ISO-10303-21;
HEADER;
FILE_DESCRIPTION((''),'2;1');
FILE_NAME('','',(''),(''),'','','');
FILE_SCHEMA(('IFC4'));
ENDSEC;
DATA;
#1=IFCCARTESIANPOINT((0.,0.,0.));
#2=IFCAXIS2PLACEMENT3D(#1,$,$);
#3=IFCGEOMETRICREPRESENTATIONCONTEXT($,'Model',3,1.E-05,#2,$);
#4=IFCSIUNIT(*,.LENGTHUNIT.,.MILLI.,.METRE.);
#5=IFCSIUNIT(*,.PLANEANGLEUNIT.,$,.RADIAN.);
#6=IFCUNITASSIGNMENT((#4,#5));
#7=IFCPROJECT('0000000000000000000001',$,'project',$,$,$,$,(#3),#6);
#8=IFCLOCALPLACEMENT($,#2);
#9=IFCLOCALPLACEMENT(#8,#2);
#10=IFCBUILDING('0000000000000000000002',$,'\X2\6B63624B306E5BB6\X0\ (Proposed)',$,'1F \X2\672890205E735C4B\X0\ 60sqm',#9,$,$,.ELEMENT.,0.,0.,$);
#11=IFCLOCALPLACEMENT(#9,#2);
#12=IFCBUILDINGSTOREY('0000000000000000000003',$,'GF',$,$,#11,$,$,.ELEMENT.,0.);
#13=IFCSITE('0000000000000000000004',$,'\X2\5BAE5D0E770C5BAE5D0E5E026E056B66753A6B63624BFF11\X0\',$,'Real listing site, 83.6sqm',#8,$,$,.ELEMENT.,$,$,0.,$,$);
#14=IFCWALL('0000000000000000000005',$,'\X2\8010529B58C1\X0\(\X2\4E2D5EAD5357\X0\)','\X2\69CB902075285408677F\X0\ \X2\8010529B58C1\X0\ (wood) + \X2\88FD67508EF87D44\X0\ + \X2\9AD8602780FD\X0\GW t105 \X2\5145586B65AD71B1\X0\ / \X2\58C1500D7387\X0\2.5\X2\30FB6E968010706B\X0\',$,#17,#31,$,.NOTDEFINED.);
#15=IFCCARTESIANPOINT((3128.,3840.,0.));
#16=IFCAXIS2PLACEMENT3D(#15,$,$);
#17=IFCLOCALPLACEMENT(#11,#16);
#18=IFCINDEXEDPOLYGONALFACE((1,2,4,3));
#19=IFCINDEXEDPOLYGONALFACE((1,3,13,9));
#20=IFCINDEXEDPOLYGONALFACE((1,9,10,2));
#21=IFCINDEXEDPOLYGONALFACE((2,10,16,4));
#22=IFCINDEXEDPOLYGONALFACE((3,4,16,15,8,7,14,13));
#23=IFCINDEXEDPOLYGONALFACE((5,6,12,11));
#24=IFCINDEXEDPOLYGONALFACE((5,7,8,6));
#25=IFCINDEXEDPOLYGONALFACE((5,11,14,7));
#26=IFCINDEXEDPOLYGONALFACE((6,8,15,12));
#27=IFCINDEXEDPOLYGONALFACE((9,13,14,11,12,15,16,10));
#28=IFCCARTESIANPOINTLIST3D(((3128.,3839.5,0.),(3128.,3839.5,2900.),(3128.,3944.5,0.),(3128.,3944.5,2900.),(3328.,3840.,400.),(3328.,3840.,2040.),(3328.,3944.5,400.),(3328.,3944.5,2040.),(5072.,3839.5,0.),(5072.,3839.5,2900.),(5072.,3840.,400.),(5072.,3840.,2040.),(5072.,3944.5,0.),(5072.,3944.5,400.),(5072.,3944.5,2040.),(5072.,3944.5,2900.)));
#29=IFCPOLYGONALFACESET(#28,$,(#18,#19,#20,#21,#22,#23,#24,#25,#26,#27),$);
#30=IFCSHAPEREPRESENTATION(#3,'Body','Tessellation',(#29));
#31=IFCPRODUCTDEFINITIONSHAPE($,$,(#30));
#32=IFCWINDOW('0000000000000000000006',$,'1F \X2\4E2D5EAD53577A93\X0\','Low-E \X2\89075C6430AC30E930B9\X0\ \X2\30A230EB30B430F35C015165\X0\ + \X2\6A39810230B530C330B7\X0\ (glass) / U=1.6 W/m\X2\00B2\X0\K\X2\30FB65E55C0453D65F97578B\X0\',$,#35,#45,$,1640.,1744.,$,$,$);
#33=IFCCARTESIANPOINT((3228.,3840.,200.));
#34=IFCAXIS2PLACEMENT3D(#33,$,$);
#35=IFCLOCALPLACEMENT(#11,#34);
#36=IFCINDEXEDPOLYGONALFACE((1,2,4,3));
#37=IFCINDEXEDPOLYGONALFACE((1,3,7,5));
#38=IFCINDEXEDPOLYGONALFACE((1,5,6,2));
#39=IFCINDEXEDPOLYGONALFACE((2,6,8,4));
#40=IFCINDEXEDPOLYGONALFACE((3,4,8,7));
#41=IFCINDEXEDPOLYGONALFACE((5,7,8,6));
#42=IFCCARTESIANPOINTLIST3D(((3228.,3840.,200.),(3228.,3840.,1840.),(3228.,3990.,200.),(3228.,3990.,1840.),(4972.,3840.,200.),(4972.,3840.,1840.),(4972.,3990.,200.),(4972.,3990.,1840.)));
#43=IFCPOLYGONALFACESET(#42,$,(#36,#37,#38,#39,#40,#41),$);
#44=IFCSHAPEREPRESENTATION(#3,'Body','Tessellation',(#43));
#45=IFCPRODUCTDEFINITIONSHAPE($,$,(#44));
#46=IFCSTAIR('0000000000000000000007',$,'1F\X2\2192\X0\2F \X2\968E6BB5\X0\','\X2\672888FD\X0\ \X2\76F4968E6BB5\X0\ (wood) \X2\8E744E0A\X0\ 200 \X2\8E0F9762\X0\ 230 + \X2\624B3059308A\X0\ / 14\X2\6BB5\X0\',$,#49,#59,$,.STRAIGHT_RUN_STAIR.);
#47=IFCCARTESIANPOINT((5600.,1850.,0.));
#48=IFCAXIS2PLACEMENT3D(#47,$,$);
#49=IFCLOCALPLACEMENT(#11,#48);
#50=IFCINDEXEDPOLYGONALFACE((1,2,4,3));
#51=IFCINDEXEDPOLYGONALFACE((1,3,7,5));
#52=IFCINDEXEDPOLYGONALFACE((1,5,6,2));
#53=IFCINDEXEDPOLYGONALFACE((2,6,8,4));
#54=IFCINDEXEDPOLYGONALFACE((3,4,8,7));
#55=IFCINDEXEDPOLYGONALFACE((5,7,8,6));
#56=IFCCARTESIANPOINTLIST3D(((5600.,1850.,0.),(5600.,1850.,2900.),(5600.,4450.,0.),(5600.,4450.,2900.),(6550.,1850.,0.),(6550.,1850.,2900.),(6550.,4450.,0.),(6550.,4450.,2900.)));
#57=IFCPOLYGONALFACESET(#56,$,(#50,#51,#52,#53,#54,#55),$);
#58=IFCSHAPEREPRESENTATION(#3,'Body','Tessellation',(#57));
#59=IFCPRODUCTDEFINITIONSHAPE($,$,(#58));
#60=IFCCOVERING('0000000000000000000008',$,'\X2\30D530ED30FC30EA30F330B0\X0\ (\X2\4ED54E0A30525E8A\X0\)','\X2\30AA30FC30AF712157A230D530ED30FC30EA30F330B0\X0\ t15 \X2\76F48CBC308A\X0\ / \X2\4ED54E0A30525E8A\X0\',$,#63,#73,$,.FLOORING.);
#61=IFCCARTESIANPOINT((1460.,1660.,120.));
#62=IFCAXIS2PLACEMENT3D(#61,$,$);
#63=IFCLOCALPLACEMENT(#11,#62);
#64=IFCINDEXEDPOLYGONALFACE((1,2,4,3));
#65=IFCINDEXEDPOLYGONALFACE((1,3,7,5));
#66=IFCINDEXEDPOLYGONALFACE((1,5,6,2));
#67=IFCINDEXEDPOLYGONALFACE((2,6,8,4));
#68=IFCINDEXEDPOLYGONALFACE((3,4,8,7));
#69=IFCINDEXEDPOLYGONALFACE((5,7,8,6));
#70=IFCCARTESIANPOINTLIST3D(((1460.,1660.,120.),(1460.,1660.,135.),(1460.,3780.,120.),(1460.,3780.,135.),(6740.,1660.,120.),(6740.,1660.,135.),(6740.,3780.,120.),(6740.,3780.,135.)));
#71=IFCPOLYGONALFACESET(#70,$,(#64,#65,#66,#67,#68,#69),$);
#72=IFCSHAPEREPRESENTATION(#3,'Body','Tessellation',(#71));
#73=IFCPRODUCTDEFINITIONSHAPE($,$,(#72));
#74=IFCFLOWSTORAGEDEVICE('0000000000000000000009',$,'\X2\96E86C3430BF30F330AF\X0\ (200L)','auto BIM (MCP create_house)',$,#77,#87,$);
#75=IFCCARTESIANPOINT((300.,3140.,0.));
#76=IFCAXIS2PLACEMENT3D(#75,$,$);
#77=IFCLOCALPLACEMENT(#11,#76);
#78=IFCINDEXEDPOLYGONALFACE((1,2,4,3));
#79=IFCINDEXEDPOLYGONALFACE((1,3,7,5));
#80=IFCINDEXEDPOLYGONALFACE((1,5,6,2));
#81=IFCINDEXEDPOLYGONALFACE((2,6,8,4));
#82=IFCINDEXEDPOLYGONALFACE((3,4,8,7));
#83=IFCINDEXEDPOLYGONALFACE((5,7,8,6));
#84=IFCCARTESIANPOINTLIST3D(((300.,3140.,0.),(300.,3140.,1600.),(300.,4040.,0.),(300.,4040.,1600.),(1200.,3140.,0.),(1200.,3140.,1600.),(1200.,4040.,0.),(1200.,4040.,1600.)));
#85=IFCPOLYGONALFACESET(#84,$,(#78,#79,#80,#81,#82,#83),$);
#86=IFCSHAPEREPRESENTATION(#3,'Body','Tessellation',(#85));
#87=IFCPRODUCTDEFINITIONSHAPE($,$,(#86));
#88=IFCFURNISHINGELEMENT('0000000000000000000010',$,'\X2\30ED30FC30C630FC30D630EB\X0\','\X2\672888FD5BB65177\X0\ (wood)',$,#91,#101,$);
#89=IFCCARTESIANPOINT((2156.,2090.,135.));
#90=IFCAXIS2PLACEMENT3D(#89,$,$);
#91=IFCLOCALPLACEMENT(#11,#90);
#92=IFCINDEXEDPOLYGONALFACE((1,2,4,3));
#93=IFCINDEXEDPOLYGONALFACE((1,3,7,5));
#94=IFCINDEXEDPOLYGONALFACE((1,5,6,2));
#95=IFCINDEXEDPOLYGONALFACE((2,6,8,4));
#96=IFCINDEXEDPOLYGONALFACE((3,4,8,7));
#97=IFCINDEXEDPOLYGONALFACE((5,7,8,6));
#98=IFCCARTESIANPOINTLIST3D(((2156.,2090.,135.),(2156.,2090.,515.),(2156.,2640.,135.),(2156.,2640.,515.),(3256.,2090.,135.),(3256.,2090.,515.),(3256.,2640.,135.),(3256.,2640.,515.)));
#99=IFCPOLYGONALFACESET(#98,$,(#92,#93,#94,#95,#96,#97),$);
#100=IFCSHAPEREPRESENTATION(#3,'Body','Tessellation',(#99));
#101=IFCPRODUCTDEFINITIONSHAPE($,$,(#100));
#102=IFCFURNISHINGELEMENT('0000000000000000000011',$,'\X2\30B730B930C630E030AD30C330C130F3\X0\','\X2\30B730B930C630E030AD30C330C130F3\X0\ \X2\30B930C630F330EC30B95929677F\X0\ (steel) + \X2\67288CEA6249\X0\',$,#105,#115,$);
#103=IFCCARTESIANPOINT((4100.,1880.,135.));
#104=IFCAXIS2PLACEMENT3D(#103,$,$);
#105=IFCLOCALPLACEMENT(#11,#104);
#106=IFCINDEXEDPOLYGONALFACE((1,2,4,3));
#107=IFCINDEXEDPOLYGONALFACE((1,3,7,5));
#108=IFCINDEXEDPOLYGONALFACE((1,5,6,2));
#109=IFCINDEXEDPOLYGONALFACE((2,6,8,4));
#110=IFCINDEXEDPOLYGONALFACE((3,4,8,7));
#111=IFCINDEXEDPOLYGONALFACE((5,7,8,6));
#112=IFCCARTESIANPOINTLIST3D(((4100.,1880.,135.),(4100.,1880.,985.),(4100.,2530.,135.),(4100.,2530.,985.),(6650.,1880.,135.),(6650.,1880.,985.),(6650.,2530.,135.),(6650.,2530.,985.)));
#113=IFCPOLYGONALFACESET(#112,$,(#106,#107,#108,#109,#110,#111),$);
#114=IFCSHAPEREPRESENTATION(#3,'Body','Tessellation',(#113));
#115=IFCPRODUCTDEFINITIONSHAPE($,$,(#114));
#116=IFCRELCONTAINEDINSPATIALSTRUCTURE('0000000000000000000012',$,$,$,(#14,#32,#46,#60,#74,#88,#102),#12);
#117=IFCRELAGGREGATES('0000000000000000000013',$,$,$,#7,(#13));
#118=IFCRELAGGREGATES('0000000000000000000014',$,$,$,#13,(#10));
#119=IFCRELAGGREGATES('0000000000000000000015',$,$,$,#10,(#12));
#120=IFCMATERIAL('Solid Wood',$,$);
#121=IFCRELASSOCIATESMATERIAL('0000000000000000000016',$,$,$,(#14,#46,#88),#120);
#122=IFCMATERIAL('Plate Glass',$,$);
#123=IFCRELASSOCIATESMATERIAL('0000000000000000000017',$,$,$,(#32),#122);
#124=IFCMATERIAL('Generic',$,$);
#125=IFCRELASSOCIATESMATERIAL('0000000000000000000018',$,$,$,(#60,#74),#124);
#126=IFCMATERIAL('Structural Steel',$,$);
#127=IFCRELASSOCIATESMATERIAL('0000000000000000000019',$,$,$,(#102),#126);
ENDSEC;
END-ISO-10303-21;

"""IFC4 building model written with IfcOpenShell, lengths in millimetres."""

from ifc_helpers import new_model, si_unit, frame, frame_2d, origin, place, context, project, spatial, rectangle, extrude, material, element, fill, save


model = new_model("IFC4")

# Units and contexts
model_context = context("Model", 3, precision=1e-05, world=origin())
ifc_project = project(units=[si_unit("LENGTHUNIT", "METRE", prefix="MILLI"), si_unit("PLANEANGLEUNIT", "RADIAN")], contexts=[model_context])

# Site, building, storey
site_placement = place(None, origin())
site = spatial("IfcSite", under=ifc_project, at=site_placement, Name="宮崎県宮崎市清武町正手１", ObjectType="Real listing site, 83.6sqm", CompositionType="ELEMENT", RefElevation=0.0)
building_placement = place(site_placement, origin())
building = spatial("IfcBuilding", under=site, at=building_placement, Name="正手の家 (Proposed)", ObjectType="1F 木造平屋 60sqm", CompositionType="ELEMENT", ElevationOfRefHeight=0.0, ElevationOfTerrain=0.0)
storey_placement = place(building_placement, origin())
storey = spatial("IfcBuildingStorey", under=building, at=storey_placement, Name="GF", CompositionType="ELEMENT", Elevation=0.0)

# Shared definitions
ifc_material_1 = material(Name="Solid Wood")

# Shared definitions
ifc_material_2 = material(Name="Plate Glass")

# Wall, opening, window
wall_1_placement = place(storey_placement, frame((3128.0, 3840.0, 0.0)))
wall_1 = element("IfcWall", 1, at=wall_1_placement, inside=storey, material=ifc_material_1, Name="耐力壁(中庭南)", Description="構造用合板 耐力壁 (wood) + 製材軸組 + 高性能GW t105 充填断熱 / 壁倍率2.5・準耐火", PredefinedType="NOTDEFINED", context=model_context, shape_type="SweptSolid", body=[
    extrude(rectangle(XDim=1944.0, YDim=105.0, at=frame_2d((972.0, 52.0))), frame((3128.0, 3840.0, 0.0)), (0.0, 0.0, 1.0), 2900.0),
])
opening_1_placement = place(storey_placement, frame((3228.0, 3840.0, 200.0)))
opening_1 = element("IfcOpeningElement", 2, at=opening_1_placement, cuts=wall_1, PredefinedType="NOTDEFINED", context=model_context, shape_type="SweptSolid", body=[
    extrude(rectangle(XDim=1744.0, YDim=150.0, at=frame_2d((872.0, 75.0))), frame((3228.0, 3840.0, 200.0)), (0.0, 0.0, 1.0), 1640.0),
])
window_1_placement = place(storey_placement, frame((3228.0, 3840.0, 200.0)))
window_1 = element("IfcWindow", 3, at=window_1_placement, inside=storey, material=ifc_material_2, Name="1F 中庭南窓", Description="Low-E 複層ガラス アルゴン封入 + 樹脂サッシ (glass) / U=1.6 W/m²K・日射取得型", OverallHeight=1640.0, OverallWidth=1744.0, context=model_context, shape_type="SweptSolid", body=[
    extrude(rectangle(XDim=1744.0, YDim=150.0, at=frame_2d((872.0, 75.0))), frame((3228.0, 3840.0, 200.0)), (0.0, 0.0, 1.0), 1640.0),
])
fill(opening_1, window_1)

# Stair
stair_placement = place(storey_placement, frame((5600.0, 1850.0, 0.0)))
element("IfcStair", 4, at=stair_placement, inside=storey, material=ifc_material_1, Name="1F→2F 階段", Description="木製 直階段 (wood) 蹴上 200 踏面 230 + 手すり / 14段", PredefinedType="STRAIGHT_RUN_STAIR", context=model_context, shape_type="SweptSolid", body=[
    extrude(rectangle(XDim=950.0, YDim=2600.0, at=frame_2d((475.0, 1300.0))), frame((5600.0, 1850.0, 0.0)), (0.0, 0.0, 1.0), 2900.0),
])

# Covering
ifc_material_3 = material(Name="Generic")
covering_placement = place(storey_placement, frame((1460.0, 1660.0, 120.0)))
element("IfcCovering", 5, at=covering_placement, inside=storey, material=ifc_material_3, Name="フローリング (仕上げ床)", Description="オーク無垢フローリング t15 直貼り / 仕上げ床", PredefinedType="FLOORING", context=model_context, shape_type="SweptSolid", body=[
    extrude(rectangle(XDim=5280.0, YDim=2120.0, at=frame_2d((2640.0, 1060.0))), frame((1460.0, 1660.0, 120.0)), (0.0, 0.0, 1.0), 15.0),
])

# Flow storage device
flow_storage_device_placement = place(storey_placement, frame((300.0, 3140.0, 0.0)))
element("IfcFlowStorageDevice", 6, at=flow_storage_device_placement, inside=storey, material=ifc_material_3, Name="雨水タンク (200L)", Description="auto BIM (MCP create_house)", context=model_context, shape_type="SweptSolid", body=[
    extrude(rectangle(XDim=900.0, YDim=900.0, at=frame_2d((450.0, 450.0))), frame((300.0, 3140.0, 0.0)), (0.0, 0.0, 1.0), 1600.0),
])

# Furnishing elements
furnishing_1_placement = place(storey_placement, frame((2156.0, 2090.0, 135.0)))
element("IfcFurnishingElement", 7, at=furnishing_1_placement, inside=storey, material=ifc_material_1, Name="ローテーブル", Description="木製家具 (wood)", context=model_context, shape_type="SweptSolid", body=[
    extrude(rectangle(XDim=1100.0, YDim=550.0, at=frame_2d((550.0, 275.0))), frame((2156.0, 2090.0, 135.0)), (0.0, 0.0, 1.0), 380.0),
])
ifc_material_4 = material(Name="Structural Steel")
furnishing_2_placement = place(storey_placement, frame((4100.0, 1880.0, 135.0)))
element("IfcFurnishingElement", 8, at=furnishing_2_placement, inside=storey, material=ifc_material_4, Name="システムキッチン", Description="システムキッチン ステンレス天板 (steel) + 木質扉", context=model_context, shape_type="SweptSolid", body=[
    extrude(rectangle(XDim=2550.0, YDim=650.0, at=frame_2d((1275.0, 325.0))), frame((4100.0, 1880.0, 135.0)), (0.0, 0.0, 1.0), 850.0),
])

save(model, "model.ifc")
